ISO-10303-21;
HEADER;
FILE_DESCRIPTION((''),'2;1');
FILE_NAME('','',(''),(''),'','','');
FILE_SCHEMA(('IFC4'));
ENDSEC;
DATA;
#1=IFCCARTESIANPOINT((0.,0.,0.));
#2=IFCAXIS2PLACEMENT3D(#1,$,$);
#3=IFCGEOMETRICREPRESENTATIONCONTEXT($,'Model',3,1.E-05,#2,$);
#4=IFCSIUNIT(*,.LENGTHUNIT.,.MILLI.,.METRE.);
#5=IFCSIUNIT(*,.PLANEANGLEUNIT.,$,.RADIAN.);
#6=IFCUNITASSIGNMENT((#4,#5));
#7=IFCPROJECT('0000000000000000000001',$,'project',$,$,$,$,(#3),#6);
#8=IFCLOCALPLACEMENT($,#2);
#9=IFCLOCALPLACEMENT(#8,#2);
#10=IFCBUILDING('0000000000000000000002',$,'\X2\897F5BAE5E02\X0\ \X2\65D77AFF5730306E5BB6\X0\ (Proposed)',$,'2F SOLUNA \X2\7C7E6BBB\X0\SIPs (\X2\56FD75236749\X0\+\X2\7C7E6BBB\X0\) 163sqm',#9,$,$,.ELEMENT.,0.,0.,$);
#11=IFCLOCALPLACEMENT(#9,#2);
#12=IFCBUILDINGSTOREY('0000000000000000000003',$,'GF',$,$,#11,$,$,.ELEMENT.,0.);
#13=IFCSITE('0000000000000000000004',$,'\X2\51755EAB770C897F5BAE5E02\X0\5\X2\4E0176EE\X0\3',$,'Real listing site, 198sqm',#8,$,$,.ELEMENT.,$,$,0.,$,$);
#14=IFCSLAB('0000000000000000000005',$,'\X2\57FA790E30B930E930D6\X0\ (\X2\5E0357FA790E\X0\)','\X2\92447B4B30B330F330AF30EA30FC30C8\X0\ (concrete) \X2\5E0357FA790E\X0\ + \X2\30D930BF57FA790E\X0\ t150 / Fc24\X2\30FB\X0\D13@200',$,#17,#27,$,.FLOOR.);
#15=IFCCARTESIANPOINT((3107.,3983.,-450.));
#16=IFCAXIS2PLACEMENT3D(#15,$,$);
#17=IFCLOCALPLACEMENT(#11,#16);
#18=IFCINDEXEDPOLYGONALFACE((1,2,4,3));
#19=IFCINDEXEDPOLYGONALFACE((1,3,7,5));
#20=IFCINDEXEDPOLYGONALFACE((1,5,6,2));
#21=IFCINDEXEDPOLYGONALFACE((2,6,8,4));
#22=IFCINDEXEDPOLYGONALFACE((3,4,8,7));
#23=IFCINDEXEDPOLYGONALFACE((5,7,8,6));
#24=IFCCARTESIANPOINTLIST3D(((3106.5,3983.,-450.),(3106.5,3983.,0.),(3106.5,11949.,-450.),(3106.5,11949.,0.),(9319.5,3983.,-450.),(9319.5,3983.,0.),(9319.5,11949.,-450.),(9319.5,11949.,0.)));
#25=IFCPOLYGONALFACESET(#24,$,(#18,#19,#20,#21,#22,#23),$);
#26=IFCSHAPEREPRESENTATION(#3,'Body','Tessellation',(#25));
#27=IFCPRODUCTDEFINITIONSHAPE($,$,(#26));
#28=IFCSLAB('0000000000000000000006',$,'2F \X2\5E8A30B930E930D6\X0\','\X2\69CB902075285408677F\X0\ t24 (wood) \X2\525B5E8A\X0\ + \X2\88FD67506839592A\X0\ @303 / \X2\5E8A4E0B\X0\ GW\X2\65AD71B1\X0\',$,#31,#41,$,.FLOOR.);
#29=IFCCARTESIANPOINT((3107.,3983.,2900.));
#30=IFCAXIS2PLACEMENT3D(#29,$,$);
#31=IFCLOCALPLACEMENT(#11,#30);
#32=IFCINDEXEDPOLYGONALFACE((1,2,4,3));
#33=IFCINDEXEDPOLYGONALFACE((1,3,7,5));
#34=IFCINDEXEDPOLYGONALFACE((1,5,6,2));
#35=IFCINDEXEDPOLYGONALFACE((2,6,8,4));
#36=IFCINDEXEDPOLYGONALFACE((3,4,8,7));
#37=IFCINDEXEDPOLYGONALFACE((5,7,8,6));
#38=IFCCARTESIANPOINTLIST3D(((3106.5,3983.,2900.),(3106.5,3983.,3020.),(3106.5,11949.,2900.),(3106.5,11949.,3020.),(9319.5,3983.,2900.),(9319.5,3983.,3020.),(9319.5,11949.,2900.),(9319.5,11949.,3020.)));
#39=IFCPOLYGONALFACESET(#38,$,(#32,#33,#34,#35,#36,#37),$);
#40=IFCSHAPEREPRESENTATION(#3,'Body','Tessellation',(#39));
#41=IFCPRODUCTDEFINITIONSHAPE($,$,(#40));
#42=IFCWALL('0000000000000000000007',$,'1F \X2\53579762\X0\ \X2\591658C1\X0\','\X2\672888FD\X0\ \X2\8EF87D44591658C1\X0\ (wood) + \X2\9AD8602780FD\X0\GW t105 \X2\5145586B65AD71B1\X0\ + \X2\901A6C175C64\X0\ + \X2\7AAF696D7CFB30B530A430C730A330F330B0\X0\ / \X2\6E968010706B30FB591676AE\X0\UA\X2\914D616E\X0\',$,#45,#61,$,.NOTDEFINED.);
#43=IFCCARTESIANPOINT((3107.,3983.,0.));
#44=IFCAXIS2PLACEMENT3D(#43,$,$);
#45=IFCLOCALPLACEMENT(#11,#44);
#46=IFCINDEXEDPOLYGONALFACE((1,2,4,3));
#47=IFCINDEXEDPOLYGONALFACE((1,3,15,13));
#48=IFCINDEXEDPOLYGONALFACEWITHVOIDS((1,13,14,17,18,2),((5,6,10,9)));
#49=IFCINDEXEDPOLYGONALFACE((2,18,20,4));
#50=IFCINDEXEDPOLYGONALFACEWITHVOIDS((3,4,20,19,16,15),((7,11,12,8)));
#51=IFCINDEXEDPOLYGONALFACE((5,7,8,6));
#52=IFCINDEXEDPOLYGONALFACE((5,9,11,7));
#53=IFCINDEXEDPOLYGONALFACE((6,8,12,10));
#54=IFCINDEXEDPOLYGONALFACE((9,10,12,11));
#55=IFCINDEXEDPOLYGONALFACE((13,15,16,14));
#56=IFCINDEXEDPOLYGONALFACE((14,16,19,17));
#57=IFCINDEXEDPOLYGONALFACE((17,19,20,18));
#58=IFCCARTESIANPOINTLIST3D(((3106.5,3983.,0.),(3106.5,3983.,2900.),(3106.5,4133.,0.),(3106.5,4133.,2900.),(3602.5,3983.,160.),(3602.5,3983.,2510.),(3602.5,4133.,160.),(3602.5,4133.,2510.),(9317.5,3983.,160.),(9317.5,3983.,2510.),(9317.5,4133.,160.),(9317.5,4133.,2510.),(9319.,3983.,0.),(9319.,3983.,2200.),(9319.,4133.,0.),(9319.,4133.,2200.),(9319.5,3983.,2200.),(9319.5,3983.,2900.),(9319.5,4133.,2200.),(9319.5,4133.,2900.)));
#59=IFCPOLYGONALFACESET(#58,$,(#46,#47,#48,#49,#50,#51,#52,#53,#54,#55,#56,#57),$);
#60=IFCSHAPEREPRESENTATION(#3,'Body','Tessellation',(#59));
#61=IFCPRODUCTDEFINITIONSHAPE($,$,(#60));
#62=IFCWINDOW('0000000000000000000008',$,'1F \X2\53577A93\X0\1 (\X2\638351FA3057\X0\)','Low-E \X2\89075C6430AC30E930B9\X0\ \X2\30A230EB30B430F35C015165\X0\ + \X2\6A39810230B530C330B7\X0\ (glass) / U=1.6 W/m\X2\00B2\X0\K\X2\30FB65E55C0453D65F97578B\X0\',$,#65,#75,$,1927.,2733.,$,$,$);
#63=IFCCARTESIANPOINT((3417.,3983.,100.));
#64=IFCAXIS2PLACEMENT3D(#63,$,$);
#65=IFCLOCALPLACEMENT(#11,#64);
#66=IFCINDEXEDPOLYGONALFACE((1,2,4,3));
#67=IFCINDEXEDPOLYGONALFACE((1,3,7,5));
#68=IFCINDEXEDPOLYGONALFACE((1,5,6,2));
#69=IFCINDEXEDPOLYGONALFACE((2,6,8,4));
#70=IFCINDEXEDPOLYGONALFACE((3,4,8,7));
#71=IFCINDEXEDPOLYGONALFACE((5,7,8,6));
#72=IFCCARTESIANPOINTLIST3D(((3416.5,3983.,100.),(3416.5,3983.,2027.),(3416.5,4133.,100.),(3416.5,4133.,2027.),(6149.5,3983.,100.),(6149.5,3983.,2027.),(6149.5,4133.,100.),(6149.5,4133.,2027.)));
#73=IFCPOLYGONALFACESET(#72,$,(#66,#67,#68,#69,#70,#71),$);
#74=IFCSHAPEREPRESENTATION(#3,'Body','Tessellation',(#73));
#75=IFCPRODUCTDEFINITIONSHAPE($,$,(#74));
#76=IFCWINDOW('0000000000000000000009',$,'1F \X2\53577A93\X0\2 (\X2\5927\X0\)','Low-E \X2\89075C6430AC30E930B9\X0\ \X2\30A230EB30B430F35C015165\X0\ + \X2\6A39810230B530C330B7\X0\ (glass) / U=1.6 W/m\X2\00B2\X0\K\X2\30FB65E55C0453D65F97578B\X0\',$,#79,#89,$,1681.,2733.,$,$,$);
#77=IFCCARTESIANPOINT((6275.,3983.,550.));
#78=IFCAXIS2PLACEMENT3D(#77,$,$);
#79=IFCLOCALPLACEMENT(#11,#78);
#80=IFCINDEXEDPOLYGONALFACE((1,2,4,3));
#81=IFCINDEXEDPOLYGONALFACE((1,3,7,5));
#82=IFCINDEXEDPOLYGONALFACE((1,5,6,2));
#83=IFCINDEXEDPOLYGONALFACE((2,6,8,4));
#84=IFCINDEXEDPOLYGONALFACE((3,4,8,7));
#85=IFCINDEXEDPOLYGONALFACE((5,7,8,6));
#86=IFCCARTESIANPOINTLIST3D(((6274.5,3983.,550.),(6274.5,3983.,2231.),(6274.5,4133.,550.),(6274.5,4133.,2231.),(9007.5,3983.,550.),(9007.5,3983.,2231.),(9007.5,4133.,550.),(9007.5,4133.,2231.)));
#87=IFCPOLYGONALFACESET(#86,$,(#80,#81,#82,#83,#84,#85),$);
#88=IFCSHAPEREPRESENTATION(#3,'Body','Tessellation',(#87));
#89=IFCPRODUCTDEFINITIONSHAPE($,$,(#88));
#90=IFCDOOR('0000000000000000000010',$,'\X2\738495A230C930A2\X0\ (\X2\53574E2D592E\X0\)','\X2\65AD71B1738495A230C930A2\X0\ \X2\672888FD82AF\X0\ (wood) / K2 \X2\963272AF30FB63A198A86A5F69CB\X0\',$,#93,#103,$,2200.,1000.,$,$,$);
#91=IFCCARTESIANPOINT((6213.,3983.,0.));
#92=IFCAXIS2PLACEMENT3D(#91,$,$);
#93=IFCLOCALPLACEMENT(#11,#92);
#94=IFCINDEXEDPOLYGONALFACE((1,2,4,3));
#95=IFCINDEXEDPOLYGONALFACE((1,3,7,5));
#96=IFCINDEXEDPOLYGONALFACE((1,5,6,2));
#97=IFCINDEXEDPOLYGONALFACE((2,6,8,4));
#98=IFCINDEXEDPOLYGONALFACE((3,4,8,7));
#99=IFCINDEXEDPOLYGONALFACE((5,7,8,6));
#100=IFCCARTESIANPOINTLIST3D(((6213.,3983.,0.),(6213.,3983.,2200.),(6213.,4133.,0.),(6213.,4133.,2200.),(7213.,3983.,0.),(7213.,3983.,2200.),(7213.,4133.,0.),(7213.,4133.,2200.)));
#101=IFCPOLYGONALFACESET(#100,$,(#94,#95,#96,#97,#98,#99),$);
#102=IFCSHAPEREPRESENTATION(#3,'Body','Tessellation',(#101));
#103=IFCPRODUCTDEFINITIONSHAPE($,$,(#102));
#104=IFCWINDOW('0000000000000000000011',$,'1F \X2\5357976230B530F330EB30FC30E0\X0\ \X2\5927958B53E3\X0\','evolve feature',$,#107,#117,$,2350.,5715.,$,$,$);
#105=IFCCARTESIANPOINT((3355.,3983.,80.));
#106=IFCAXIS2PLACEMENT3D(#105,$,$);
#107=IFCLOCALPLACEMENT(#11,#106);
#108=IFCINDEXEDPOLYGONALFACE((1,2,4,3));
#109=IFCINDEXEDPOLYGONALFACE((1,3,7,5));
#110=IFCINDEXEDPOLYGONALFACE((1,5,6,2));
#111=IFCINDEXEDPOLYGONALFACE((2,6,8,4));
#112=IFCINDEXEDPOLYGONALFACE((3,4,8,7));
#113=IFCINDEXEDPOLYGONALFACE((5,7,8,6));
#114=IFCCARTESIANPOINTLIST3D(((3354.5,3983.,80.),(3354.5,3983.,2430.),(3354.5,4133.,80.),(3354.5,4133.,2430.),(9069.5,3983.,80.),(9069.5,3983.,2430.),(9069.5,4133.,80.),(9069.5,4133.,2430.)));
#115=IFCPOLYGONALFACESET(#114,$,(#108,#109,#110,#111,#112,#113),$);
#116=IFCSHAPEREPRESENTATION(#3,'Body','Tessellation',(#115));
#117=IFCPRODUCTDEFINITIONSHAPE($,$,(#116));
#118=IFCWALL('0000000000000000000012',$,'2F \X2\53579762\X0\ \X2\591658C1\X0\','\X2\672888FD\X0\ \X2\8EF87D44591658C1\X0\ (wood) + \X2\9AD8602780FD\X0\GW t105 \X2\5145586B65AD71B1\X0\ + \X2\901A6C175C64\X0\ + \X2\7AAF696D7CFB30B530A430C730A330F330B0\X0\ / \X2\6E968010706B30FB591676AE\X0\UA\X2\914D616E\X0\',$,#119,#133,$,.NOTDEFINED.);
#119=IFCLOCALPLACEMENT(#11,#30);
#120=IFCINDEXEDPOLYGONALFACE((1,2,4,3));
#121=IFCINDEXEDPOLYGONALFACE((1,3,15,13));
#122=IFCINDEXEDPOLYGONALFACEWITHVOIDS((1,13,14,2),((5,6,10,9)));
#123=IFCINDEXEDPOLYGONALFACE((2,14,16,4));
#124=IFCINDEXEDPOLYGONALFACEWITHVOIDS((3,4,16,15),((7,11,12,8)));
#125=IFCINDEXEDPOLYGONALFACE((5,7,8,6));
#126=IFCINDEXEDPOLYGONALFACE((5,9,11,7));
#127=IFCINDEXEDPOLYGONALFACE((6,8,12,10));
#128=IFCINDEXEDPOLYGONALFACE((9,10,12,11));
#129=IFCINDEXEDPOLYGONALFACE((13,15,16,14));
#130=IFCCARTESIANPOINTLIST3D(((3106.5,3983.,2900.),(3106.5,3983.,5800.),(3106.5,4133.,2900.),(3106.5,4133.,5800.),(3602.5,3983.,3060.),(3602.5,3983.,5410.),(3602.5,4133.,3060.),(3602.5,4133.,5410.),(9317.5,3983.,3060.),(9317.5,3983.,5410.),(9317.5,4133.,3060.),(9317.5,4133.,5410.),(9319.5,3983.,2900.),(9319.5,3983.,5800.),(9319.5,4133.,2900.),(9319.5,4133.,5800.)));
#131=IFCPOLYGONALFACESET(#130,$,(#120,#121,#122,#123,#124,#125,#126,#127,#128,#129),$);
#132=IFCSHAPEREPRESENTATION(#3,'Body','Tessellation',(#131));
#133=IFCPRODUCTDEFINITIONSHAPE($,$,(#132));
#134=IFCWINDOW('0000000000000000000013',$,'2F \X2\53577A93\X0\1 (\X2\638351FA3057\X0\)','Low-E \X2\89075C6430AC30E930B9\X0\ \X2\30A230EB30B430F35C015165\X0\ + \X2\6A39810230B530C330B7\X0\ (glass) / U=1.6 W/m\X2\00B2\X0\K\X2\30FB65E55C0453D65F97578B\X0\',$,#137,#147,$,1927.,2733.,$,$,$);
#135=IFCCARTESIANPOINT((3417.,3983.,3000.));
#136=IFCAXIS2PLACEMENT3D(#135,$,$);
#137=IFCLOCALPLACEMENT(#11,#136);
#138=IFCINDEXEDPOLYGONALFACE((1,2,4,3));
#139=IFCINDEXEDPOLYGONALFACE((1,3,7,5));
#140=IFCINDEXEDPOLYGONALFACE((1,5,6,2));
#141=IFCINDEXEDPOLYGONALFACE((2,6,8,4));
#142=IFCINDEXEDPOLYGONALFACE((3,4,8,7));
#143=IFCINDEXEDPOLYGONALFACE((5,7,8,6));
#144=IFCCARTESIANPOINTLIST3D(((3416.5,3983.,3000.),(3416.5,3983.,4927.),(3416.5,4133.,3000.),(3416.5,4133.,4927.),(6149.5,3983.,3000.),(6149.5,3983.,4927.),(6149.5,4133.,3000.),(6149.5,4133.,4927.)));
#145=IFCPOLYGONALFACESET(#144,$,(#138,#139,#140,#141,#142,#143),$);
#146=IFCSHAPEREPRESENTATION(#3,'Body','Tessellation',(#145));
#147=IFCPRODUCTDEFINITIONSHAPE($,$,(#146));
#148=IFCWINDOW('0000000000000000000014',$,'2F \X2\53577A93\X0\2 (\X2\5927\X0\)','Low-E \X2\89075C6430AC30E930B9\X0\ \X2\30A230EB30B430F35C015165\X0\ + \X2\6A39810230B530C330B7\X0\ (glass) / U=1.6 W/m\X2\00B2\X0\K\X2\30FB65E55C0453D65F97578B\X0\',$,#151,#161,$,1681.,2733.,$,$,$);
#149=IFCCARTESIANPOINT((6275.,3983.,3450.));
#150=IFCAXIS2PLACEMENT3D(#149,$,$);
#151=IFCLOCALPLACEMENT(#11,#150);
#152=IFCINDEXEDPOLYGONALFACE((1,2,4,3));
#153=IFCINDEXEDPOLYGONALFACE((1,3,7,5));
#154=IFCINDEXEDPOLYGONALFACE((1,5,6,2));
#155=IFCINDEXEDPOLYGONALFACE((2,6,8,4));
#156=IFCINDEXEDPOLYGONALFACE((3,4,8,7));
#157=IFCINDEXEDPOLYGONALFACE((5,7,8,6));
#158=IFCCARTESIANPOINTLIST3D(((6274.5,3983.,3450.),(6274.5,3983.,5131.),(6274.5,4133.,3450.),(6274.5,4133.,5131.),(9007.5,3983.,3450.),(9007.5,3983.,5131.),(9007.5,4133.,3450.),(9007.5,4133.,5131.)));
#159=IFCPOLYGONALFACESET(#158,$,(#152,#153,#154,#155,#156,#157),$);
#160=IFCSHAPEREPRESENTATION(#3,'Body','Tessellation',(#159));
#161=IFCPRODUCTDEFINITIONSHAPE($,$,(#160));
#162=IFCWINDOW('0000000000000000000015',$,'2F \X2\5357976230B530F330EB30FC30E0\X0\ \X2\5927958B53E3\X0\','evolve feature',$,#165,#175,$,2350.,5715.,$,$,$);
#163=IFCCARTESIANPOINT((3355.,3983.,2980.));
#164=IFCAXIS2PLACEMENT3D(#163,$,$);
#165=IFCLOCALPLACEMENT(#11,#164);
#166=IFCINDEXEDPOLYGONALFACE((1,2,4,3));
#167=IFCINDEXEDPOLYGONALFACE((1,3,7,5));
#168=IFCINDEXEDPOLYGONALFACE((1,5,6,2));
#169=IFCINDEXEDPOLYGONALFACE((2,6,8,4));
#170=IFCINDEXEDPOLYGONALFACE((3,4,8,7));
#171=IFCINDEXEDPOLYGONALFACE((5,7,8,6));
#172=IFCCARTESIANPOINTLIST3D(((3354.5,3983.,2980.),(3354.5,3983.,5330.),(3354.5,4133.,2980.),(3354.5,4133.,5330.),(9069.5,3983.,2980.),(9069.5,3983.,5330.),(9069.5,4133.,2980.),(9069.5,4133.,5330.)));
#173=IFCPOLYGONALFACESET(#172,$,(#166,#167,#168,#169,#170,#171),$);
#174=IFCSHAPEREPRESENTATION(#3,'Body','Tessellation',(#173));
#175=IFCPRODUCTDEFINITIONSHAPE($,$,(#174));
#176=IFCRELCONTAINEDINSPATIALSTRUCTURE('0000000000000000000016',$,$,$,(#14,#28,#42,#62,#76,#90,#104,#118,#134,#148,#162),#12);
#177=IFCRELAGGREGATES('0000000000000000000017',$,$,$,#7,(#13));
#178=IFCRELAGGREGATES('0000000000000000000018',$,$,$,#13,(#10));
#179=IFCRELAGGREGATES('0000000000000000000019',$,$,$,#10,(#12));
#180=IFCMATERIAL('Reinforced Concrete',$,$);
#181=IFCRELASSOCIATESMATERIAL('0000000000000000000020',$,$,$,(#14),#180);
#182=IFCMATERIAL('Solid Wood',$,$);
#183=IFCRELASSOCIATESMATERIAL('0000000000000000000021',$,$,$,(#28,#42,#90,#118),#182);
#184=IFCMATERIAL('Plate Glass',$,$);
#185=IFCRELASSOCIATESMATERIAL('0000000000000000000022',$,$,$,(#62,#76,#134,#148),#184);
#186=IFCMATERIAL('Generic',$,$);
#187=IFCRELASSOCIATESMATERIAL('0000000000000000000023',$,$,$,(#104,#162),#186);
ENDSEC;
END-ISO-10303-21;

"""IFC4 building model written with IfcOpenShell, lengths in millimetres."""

from ifc_helpers import new_model, si_unit, frame, frame_2d, origin, place, context, project, spatial, rectangle, extrude, material, element, fill, save


model = new_model("IFC4")

# Units and contexts
model_context = context("Model", 3, precision=1e-05, world=origin())
ifc_project = project(units=[si_unit("LENGTHUNIT", "METRE", prefix="MILLI"), si_unit("PLANEANGLEUNIT", "RADIAN")], contexts=[model_context])

# Site, building, storey
site_placement = place(None, origin())
site = spatial("IfcSite", under=ifc_project, at=site_placement, Name="兵庫県西宮市5丁目3", ObjectType="Real listing site, 198sqm", CompositionType="ELEMENT", RefElevation=0.0)
building_placement = place(site_placement, origin())
building = spatial("IfcBuilding", under=site, at=building_placement, Name="西宮市 旗竿地の家 (Proposed)", ObjectType="2F SOLUNA 籾殻SIPs (国産杉+籾殻) 163sqm", CompositionType="ELEMENT", ElevationOfRefHeight=0.0, ElevationOfTerrain=0.0)
storey_placement = place(building_placement, origin())
storey = spatial("IfcBuildingStorey", under=building, at=storey_placement, Name="GF", CompositionType="ELEMENT", Elevation=0.0)

# Slabs
ifc_material_1 = material(Name="Reinforced Concrete")
slab_1_placement = place(storey_placement, frame((3107.0, 3983.0, -450.0)))
element("IfcSlab", 1, at=slab_1_placement, inside=storey, material=ifc_material_1, Name="基礎スラブ (布基礎)", Description="鉄筋コンクリート (concrete) 布基礎 + ベタ基礎 t150 / Fc24・D13@200", PredefinedType="FLOOR", context=model_context, shape_type="SweptSolid", body=[
    extrude(rectangle(XDim=6213.0, YDim=7966.0, at=frame_2d((3106.0, 3983.0))), frame((3107.0, 3983.0, -450.0)), (0.0, 0.0, 1.0), 450.0),
])
ifc_material_2 = material(Name="Solid Wood")
slab_2_placement = place(storey_placement, frame((3107.0, 3983.0, 2900.0)))
element("IfcSlab", 2, at=slab_2_placement, inside=storey, material=ifc_material_2, Name="2F 床スラブ", Description="構造用合板 t24 (wood) 剛床 + 製材根太 @303 / 床下 GW断熱", PredefinedType="FLOOR", context=model_context, shape_type="SweptSolid", body=[
    extrude(rectangle(XDim=6213.0, YDim=7966.0, at=frame_2d((3106.0, 3983.0))), frame((3107.0, 3983.0, 2900.0)), (0.0, 0.0, 1.0), 120.0),
])
ifc_material_3 = material(Name="Generic")

# Wall, openings, windows, door
wall_1_placement = place(storey_placement, frame((3107.0, 3983.0, 0.0)))
wall_1 = element("IfcWall", 3, at=wall_1_placement, inside=storey, material=ifc_material_2, Name="1F 南面 外壁", Description="木製 軸組外壁 (wood) + 高性能GW t105 充填断熱 + 通気層 + 窯業系サイディング / 準耐火・外皮UA配慮", PredefinedType="NOTDEFINED", context=model_context, shape_type="SweptSolid", body=[
    extrude(rectangle(XDim=6213.0, YDim=150.0, at=frame_2d((3106.0, 75.0))), frame((3107.0, 3983.0, 0.0)), (0.0, 0.0, 1.0), 2900.0),
])
opening_1_placement = place(storey_placement, frame((3417.0, 3983.0, 100.0)))
opening_1 = element("IfcOpeningElement", 4, at=opening_1_placement, cuts=wall_1, PredefinedType="NOTDEFINED", context=model_context, shape_type="SweptSolid", body=[
    extrude(rectangle(XDim=2733.0, YDim=150.0, at=frame_2d((1366.0, 75.0))), frame((3417.0, 3983.0, 100.0)), (0.0, 0.0, 1.0), 1927.0),
])
opening_2_placement = place(storey_placement, frame((6275.0, 3983.0, 550.0)))
opening_2 = element("IfcOpeningElement", 5, at=opening_2_placement, cuts=wall_1, PredefinedType="NOTDEFINED", context=model_context, shape_type="SweptSolid", body=[
    extrude(rectangle(XDim=2733.0, YDim=150.0, at=frame_2d((1366.0, 75.0))), frame((6275.0, 3983.0, 550.0)), (0.0, 0.0, 1.0), 1681.0),
])
opening_3_placement = place(storey_placement, frame((6213.0, 3983.0, 0.0)))
opening_3 = element("IfcOpeningElement", 6, at=opening_3_placement, cuts=wall_1, PredefinedType="NOTDEFINED", context=model_context, shape_type="SweptSolid", body=[
    extrude(rectangle(XDim=1000.0, YDim=150.0, at=frame_2d((500.0, 75.0))), frame((6213.0, 3983.0, 0.0)), (0.0, 0.0, 1.0), 2200.0),
])
opening_4_placement = place(storey_placement, frame((3355.0, 3983.0, 80.0)))
opening_4 = element("IfcOpeningElement", 7, at=opening_4_placement, cuts=wall_1, PredefinedType="NOTDEFINED", context=model_context, shape_type="SweptSolid", body=[
    extrude(rectangle(XDim=5715.0, YDim=150.0, at=frame_2d((2857.0, 75.0))), frame((3355.0, 3983.0, 80.0)), (0.0, 0.0, 1.0), 2350.0),
])
ifc_material_4 = material(Name="Plate Glass")
window_1_placement = place(storey_placement, frame((3417.0, 3983.0, 100.0)))
window_1 = element("IfcWindow", 8, at=window_1_placement, inside=storey, material=ifc_material_4, Name="1F 南窓1 (掃出し)", Description="Low-E 複層ガラス アルゴン封入 + 樹脂サッシ (glass) / U=1.6 W/m²K・日射取得型", OverallHeight=1927.0, OverallWidth=2733.0, context=model_context, shape_type="SweptSolid", body=[
    extrude(rectangle(XDim=2733.0, YDim=150.0, at=frame_2d((1366.0, 75.0))), frame((3417.0, 3983.0, 100.0)), (0.0, 0.0, 1.0), 1927.0),
])
fill(opening_1, window_1)
window_2_placement = place(storey_placement, frame((6275.0, 3983.0, 550.0)))
window_2 = element("IfcWindow", 9, at=window_2_placement, inside=storey, material=ifc_material_4, Name="1F 南窓2 (大)", Description="Low-E 複層ガラス アルゴン封入 + 樹脂サッシ (glass) / U=1.6 W/m²K・日射取得型", OverallHeight=1681.0, OverallWidth=2733.0, context=model_context, shape_type="SweptSolid", body=[
    extrude(rectangle(XDim=2733.0, YDim=150.0, at=frame_2d((1366.0, 75.0))), frame((6275.0, 3983.0, 550.0)), (0.0, 0.0, 1.0), 1681.0),
])
fill(opening_2, window_2)
door_placement = place(storey_placement, frame((6213.0, 3983.0, 0.0)))
door = element("IfcDoor", 10, at=door_placement, inside=storey, material=ifc_material_2, Name="玄関ドア (南中央)", Description="断熱玄関ドア 木製芯 (wood) / K2 防犯・採風機構", OverallHeight=2200.0, OverallWidth=1000.0, context=model_context, shape_type="SweptSolid", body=[
    extrude(rectangle(XDim=1000.0, YDim=150.0, at=frame_2d((500.0, 75.0))), frame((6213.0, 3983.0, 0.0)), (0.0, 0.0, 1.0), 2200.0),
])
fill(opening_3, door)
window_3_placement = place(storey_placement, frame((3355.0, 3983.0, 80.0)))
window_3 = element("IfcWindow", 11, at=window_3_placement, inside=storey, material=ifc_material_3, Name="1F 南面サンルーム 大開口", Description="evolve feature", OverallHeight=2350.0, OverallWidth=5715.0, context=model_context, shape_type="SweptSolid", body=[
    extrude(rectangle(XDim=5715.0, YDim=150.0, at=frame_2d((2857.0, 75.0))), frame((3355.0, 3983.0, 80.0)), (0.0, 0.0, 1.0), 2350.0),
])
fill(opening_4, window_3)

# Wall, openings, windows
wall_2_placement = place(storey_placement, frame((3107.0, 3983.0, 2900.0)))
wall_2 = element("IfcWall", 12, at=wall_2_placement, inside=storey, material=ifc_material_2, Name="2F 南面 外壁", Description="木製 軸組外壁 (wood) + 高性能GW t105 充填断熱 + 通気層 + 窯業系サイディング / 準耐火・外皮UA配慮", PredefinedType="NOTDEFINED", context=model_context, shape_type="SweptSolid", body=[
    extrude(rectangle(XDim=6213.0, YDim=150.0, at=frame_2d((3106.0, 75.0))), frame((3107.0, 3983.0, 2900.0)), (0.0, 0.0, 1.0), 2900.0),
])
opening_5_placement = place(storey_placement, frame((3417.0, 3983.0, 3000.0)))
opening_5 = element("IfcOpeningElement", 13, at=opening_5_placement, cuts=wall_2, PredefinedType="NOTDEFINED", context=model_context, shape_type="SweptSolid", body=[
    extrude(rectangle(XDim=2733.0, YDim=150.0, at=frame_2d((1366.0, 75.0))), frame((3417.0, 3983.0, 3000.0)), (0.0, 0.0, 1.0), 1927.0),
])
opening_6_placement = place(storey_placement, frame((6275.0, 3983.0, 3450.0)))
opening_6 = element("IfcOpeningElement", 14, at=opening_6_placement, cuts=wall_2, PredefinedType="NOTDEFINED", context=model_context, shape_type="SweptSolid", body=[
    extrude(rectangle(XDim=2733.0, YDim=150.0, at=frame_2d((1366.0, 75.0))), frame((6275.0, 3983.0, 3450.0)), (0.0, 0.0, 1.0), 1681.0),
])
opening_7_placement = place(storey_placement, frame((3355.0, 3983.0, 2980.0)))
opening_7 = element("IfcOpeningElement", 15, at=opening_7_placement, cuts=wall_2, PredefinedType="NOTDEFINED", context=model_context, shape_type="SweptSolid", body=[
    extrude(rectangle(XDim=5715.0, YDim=150.0, at=frame_2d((2857.0, 75.0))), frame((3355.0, 3983.0, 2980.0)), (0.0, 0.0, 1.0), 2350.0),
])
window_4_placement = place(storey_placement, frame((3417.0, 3983.0, 3000.0)))
window_4 = element("IfcWindow", 16, at=window_4_placement, inside=storey, material=ifc_material_4, Name="2F 南窓1 (掃出し)", Description="Low-E 複層ガラス アルゴン封入 + 樹脂サッシ (glass) / U=1.6 W/m²K・日射取得型", OverallHeight=1927.0, OverallWidth=2733.0, context=model_context, shape_type="SweptSolid", body=[
    extrude(rectangle(XDim=2733.0, YDim=150.0, at=frame_2d((1366.0, 75.0))), frame((3417.0, 3983.0, 3000.0)), (0.0, 0.0, 1.0), 1927.0),
])
fill(opening_5, window_4)
window_5_placement = place(storey_placement, frame((6275.0, 3983.0, 3450.0)))
window_5 = element("IfcWindow", 17, at=window_5_placement, inside=storey, material=ifc_material_4, Name="2F 南窓2 (大)", Description="Low-E 複層ガラス アルゴン封入 + 樹脂サッシ (glass) / U=1.6 W/m²K・日射取得型", OverallHeight=1681.0, OverallWidth=2733.0, context=model_context, shape_type="SweptSolid", body=[
    extrude(rectangle(XDim=2733.0, YDim=150.0, at=frame_2d((1366.0, 75.0))), frame((6275.0, 3983.0, 3450.0)), (0.0, 0.0, 1.0), 1681.0),
])
fill(opening_6, window_5)
window_6_placement = place(storey_placement, frame((3355.0, 3983.0, 2980.0)))
window_6 = element("IfcWindow", 18, at=window_6_placement, inside=storey, material=ifc_material_3, Name="2F 南面サンルーム 大開口", Description="evolve feature", OverallHeight=2350.0, OverallWidth=5715.0, context=model_context, shape_type="SweptSolid", body=[
    extrude(rectangle(XDim=5715.0, YDim=150.0, at=frame_2d((2857.0, 75.0))), frame((3355.0, 3983.0, 2980.0)), (0.0, 0.0, 1.0), 2350.0),
])
fill(opening_7, window_6)

save(model, "model.ifc")
